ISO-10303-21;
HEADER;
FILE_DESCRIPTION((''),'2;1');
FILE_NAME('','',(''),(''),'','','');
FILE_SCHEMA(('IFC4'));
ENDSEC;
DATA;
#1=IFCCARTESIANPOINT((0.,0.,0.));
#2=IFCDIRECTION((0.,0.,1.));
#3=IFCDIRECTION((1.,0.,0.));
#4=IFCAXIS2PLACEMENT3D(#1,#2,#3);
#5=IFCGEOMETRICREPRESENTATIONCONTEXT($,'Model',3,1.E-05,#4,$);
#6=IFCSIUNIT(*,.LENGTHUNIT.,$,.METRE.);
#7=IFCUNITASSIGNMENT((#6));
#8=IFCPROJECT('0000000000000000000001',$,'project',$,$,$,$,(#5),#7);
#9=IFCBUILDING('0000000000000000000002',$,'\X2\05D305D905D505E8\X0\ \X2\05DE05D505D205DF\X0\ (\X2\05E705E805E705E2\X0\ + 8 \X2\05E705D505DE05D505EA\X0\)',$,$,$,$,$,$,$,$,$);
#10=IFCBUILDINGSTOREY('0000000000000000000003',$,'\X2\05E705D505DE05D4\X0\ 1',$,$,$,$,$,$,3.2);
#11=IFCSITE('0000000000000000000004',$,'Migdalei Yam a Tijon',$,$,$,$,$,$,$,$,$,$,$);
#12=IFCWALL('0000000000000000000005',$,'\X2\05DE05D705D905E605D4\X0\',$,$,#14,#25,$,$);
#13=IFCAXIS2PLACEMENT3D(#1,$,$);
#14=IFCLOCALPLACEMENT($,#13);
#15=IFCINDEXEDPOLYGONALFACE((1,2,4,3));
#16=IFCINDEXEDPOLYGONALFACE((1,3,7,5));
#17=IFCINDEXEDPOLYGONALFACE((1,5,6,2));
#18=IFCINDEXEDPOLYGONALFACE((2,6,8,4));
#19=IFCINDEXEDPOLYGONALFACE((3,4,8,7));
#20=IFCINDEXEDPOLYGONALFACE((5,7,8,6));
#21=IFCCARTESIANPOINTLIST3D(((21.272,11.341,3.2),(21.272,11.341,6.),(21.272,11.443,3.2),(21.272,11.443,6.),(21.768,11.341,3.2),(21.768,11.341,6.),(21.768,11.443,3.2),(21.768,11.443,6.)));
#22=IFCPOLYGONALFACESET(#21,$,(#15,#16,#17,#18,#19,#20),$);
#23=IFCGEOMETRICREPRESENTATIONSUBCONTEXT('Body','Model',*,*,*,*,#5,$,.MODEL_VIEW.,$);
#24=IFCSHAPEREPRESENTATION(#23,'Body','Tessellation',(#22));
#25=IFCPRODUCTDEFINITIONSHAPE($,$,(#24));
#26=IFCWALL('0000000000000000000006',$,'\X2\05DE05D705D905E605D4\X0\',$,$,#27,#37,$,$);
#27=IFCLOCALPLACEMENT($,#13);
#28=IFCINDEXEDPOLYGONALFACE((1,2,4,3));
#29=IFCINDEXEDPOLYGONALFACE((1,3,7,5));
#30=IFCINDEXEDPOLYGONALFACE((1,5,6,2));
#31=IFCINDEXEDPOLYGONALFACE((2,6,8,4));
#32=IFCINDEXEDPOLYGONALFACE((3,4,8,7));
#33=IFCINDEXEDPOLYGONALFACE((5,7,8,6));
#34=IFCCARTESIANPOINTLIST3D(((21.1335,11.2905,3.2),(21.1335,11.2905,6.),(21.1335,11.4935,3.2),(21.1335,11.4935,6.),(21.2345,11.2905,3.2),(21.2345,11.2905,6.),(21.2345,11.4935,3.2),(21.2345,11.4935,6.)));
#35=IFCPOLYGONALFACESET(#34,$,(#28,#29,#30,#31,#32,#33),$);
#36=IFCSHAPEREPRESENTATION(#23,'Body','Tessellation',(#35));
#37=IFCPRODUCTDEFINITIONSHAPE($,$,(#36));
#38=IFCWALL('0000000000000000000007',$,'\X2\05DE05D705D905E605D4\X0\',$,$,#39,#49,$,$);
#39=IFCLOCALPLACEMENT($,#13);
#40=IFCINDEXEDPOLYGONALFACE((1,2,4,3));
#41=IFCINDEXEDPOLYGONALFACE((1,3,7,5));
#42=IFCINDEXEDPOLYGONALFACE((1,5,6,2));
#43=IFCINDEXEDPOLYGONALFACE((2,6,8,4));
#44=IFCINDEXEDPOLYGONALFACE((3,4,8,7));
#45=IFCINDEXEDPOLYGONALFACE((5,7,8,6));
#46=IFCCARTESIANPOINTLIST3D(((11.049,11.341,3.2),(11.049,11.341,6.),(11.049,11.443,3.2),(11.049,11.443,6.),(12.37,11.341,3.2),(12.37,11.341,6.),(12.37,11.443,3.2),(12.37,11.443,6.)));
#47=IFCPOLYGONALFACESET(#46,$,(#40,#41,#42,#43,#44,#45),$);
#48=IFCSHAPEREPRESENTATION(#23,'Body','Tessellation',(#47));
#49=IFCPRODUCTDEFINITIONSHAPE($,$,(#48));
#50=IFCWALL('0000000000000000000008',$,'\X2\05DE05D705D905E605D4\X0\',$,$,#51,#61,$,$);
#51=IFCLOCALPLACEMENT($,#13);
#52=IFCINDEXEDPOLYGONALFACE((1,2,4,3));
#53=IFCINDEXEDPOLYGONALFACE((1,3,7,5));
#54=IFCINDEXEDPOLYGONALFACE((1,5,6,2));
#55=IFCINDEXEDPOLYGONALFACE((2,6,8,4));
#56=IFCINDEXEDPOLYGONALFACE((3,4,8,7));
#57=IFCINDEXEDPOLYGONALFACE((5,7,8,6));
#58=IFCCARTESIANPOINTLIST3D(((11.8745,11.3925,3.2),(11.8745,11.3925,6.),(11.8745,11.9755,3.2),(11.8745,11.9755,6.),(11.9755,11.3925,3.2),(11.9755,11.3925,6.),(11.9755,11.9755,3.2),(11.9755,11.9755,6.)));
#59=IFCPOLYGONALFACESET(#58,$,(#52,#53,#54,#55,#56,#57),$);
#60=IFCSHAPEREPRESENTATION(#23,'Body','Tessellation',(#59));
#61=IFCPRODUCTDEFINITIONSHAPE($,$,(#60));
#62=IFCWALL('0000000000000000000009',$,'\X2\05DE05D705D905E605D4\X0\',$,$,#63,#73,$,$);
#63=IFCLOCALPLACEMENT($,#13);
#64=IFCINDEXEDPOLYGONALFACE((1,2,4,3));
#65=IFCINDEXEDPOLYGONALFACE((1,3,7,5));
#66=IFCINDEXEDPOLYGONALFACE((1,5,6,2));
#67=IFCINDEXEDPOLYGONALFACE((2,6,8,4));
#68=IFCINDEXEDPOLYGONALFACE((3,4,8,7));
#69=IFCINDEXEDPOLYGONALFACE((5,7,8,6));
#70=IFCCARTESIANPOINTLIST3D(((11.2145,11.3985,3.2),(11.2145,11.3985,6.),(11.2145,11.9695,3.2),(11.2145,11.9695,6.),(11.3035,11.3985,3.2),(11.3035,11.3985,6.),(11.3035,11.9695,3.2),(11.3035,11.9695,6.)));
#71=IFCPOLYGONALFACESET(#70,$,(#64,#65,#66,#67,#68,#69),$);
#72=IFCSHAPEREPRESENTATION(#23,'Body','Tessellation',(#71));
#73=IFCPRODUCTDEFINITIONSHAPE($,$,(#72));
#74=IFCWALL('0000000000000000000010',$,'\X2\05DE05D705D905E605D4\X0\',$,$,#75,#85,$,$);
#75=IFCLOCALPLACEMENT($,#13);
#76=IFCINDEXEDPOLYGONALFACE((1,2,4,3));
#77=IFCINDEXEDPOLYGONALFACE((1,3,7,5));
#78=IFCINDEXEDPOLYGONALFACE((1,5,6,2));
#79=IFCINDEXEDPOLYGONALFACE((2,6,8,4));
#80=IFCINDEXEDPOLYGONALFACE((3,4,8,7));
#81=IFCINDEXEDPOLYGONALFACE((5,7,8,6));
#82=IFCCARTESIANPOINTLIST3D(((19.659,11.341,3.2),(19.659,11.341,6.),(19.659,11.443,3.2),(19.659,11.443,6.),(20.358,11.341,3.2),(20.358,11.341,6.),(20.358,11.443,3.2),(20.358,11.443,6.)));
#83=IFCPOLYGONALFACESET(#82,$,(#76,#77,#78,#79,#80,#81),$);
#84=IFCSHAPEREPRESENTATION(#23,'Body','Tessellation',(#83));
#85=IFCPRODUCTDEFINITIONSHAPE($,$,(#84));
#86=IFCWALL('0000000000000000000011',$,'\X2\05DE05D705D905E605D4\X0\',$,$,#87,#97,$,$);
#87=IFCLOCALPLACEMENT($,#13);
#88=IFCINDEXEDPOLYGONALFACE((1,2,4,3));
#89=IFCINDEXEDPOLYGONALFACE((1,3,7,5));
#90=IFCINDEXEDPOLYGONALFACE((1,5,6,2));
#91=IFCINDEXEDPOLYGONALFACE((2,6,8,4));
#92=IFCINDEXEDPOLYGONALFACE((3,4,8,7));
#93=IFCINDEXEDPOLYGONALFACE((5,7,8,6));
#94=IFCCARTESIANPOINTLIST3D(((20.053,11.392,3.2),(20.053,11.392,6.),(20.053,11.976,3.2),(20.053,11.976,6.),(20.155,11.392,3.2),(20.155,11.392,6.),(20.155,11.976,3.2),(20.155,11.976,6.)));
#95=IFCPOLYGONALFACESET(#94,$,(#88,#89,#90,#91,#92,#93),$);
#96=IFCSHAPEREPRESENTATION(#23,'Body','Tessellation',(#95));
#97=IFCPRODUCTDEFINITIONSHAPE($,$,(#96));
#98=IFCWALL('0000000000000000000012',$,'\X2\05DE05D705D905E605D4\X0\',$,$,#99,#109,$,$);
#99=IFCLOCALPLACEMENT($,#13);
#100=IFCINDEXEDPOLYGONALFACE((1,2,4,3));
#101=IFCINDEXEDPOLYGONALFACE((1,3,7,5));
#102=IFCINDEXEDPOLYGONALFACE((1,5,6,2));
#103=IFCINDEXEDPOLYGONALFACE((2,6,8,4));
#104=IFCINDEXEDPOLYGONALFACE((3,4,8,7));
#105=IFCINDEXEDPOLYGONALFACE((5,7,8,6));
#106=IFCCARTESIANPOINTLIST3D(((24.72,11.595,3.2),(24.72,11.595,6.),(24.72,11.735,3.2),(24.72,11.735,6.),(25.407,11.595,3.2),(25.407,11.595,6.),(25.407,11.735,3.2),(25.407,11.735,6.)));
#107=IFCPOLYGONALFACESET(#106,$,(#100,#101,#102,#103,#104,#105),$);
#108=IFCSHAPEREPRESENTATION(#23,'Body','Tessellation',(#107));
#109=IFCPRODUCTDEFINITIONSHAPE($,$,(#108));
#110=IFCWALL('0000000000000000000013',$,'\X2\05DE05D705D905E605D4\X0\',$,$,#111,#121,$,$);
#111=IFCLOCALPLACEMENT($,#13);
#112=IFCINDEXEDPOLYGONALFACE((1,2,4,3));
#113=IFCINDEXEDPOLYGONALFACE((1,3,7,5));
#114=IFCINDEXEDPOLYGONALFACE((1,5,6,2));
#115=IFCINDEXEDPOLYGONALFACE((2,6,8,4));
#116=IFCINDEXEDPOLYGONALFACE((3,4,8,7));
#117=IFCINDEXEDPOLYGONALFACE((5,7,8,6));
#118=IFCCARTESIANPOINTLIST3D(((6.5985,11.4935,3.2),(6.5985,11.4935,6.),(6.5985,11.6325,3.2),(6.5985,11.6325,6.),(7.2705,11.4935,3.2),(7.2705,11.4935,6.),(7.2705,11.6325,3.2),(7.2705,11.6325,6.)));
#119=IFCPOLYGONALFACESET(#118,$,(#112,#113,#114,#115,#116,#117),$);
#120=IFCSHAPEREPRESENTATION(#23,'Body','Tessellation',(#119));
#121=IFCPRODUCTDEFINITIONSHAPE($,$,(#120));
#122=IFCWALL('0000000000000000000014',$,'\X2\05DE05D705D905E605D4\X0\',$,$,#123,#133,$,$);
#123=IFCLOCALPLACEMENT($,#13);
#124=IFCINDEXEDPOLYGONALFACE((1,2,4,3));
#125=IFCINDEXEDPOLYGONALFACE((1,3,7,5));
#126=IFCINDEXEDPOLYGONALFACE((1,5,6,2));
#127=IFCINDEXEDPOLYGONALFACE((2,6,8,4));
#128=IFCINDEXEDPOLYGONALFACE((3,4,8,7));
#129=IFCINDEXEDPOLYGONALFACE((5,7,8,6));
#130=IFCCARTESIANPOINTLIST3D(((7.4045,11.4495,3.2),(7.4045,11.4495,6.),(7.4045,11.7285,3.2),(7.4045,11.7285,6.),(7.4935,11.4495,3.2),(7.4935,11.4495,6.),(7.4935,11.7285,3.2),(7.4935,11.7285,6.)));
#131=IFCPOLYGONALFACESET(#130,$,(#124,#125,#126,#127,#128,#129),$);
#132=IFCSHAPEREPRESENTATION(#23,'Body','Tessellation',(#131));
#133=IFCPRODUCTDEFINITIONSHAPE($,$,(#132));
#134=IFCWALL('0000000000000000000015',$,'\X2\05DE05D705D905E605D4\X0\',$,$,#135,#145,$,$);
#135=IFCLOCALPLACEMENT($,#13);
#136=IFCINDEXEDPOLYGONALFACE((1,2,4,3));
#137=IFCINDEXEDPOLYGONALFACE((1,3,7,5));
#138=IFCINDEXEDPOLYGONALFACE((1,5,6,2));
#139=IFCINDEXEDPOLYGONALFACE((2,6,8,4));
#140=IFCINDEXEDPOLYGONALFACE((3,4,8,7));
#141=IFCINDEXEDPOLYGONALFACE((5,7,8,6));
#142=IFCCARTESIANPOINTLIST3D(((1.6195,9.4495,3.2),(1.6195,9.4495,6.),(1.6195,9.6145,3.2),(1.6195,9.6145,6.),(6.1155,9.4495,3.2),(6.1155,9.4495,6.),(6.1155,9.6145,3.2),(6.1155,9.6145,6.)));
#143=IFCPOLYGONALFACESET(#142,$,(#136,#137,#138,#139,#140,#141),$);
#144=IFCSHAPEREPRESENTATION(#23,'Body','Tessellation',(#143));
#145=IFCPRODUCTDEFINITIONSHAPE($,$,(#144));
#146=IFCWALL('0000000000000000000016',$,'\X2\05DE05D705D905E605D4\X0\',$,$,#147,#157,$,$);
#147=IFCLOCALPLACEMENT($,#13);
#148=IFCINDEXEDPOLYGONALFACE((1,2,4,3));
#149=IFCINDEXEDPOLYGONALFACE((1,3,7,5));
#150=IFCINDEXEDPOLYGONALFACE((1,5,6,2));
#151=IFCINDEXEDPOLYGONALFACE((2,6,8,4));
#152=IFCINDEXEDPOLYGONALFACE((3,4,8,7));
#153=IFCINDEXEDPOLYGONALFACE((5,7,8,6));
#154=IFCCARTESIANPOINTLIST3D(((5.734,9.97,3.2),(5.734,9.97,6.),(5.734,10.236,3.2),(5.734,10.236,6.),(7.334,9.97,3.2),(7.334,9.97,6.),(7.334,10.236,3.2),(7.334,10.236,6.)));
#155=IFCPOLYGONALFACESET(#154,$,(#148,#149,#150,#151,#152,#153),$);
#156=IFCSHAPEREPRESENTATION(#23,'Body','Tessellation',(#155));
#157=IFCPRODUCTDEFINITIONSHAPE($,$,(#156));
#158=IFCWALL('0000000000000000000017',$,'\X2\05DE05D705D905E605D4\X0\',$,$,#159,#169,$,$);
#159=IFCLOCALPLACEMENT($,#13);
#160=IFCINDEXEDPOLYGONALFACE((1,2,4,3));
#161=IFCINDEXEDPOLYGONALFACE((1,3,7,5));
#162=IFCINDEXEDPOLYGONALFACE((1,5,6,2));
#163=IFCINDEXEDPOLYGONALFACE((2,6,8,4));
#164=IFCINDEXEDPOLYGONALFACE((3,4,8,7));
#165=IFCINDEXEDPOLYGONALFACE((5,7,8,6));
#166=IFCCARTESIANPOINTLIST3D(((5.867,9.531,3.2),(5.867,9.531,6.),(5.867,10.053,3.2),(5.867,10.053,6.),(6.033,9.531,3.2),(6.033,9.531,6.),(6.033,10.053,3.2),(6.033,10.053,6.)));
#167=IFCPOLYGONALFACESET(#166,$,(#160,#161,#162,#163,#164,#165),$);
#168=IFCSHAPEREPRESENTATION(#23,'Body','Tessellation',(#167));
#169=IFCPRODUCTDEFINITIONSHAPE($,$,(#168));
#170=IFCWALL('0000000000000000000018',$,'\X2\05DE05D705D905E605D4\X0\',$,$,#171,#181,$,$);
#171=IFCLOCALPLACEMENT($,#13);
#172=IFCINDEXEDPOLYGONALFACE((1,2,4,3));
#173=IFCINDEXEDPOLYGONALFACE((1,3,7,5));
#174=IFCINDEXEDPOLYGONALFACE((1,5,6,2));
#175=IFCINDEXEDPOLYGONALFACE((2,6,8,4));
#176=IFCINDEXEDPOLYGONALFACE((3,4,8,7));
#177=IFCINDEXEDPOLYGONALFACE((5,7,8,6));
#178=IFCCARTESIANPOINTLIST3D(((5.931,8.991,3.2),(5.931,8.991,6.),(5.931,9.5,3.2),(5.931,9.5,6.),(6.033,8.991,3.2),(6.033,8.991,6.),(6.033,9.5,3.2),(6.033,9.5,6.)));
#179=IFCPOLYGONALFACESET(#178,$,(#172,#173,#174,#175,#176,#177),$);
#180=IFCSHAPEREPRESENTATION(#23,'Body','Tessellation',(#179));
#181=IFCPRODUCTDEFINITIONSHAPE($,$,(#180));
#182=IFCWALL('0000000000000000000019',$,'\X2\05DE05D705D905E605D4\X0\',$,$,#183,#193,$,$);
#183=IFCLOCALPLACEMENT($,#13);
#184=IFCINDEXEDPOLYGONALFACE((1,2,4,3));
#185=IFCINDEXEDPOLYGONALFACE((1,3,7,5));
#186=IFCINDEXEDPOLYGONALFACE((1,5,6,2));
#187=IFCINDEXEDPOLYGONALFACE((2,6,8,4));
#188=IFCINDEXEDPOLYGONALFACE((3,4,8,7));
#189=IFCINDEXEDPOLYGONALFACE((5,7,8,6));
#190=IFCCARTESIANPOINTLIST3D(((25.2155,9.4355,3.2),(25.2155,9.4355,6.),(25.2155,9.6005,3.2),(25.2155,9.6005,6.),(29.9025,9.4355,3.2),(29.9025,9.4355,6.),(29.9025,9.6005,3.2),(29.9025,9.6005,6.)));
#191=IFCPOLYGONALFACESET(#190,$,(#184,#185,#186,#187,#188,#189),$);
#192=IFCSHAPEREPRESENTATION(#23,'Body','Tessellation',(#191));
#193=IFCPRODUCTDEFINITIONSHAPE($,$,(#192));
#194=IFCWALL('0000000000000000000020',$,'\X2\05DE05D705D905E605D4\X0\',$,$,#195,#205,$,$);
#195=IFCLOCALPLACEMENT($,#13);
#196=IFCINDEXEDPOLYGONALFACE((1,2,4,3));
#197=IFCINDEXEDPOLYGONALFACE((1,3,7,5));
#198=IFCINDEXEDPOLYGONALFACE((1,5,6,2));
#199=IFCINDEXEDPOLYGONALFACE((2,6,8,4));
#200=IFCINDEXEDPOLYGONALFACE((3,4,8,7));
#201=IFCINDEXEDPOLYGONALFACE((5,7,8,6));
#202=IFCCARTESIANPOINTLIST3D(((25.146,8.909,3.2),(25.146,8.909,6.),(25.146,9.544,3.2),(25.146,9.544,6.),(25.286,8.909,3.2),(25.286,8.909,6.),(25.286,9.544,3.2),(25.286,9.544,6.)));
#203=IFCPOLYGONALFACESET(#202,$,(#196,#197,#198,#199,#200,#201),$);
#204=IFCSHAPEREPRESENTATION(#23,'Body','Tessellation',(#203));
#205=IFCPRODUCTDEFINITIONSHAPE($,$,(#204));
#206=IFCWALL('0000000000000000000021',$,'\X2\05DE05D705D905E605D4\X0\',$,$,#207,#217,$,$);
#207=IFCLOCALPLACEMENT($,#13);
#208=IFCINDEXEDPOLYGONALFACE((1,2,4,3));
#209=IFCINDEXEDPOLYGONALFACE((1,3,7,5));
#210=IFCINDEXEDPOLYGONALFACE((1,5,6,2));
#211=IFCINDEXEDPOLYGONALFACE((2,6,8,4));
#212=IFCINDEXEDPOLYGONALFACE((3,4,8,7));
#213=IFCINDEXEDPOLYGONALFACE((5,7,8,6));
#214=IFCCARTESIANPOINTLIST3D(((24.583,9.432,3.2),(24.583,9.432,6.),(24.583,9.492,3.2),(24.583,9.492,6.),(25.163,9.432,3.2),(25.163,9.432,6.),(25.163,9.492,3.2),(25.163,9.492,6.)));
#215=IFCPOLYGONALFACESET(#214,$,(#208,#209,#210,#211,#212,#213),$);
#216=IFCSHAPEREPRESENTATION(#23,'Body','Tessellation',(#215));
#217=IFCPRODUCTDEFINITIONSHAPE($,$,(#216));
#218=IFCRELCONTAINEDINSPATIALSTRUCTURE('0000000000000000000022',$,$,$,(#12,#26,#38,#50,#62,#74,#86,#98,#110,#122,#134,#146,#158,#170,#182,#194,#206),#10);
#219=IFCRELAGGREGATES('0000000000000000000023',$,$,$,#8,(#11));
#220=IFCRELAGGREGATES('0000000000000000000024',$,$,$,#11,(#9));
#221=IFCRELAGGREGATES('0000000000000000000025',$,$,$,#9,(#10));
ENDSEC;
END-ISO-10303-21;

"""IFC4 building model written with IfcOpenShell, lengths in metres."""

from ifc_helpers import new_model, si_unit, frame, origin_with_axes, context, subcontext, project, spatial, line, indexed_curve, outline, extrude, element, save


model = new_model("IFC4")

# Units and contexts
model_context = context("Model", 3, precision=1e-05, world=origin_with_axes())
body_context = subcontext(model_context, "Body", "Model", "MODEL_VIEW")
ifc_project = project(units=[si_unit("LENGTHUNIT", "METRE")], contexts=[model_context])

# Site, building, storey
site = spatial("IfcSite", under=ifc_project, Name="Migdalei Yam a Tijon")
building = spatial("IfcBuilding", under=site, Name="דיור מוגן (קרקע + 8 קומות)")
storey = spatial("IfcBuildingStorey", under=building, Name="קומה 1", Elevation=3.2)

# Walls
element("IfcWall", 1, inside=storey, Name="מחיצה", context=body_context, shape_type="SweptSolid", body=[
    extrude(outline(indexed_curve([(0.0, 0.0), (0.496, 0.0), (0.496, 0.102), (0.0, 0.102)], segments=[line(1, 2, 3, 4, 1)])), frame((21.272, 11.341, 3.2), z_axis=(0.0, 0.0, 1.0), x_axis=(1.0, 0.0, 0.0)), (0.0, 0.0, 1.0), 2.8),
])
element("IfcWall", 2, inside=storey, Name="מחיצה", context=body_context, shape_type="SweptSolid", body=[
    extrude(outline(indexed_curve([(0.0, 0.0), (0.101, 0.0), (0.101, 0.203), (0.0, 0.203)], segments=[line(1, 2, 3, 4, 1)])), frame((21.1335, 11.2905, 3.2), z_axis=(0.0, 0.0, 1.0), x_axis=(1.0, 0.0, 0.0)), (0.0, 0.0, 1.0), 2.8),
])
element("IfcWall", 3, inside=storey, Name="מחיצה", context=body_context, shape_type="SweptSolid", body=[
    extrude(outline(indexed_curve([(0.0, 0.0), (1.321, 0.0), (1.321, 0.102), (0.0, 0.102)], segments=[line(1, 2, 3, 4, 1)])), frame((11.049, 11.341, 3.2), z_axis=(0.0, 0.0, 1.0), x_axis=(1.0, 0.0, 0.0)), (0.0, 0.0, 1.0), 2.8),
])
element("IfcWall", 4, inside=storey, Name="מחיצה", context=body_context, shape_type="SweptSolid", body=[
    extrude(outline(indexed_curve([(0.0, 0.0), (0.101, 0.0), (0.101, 0.583), (0.0, 0.583)], segments=[line(1, 2, 3, 4, 1)])), frame((11.8745, 11.3925, 3.2), z_axis=(0.0, 0.0, 1.0), x_axis=(1.0, 0.0, 0.0)), (0.0, 0.0, 1.0), 2.8),
])
element("IfcWall", 5, inside=storey, Name="מחיצה", context=body_context, shape_type="SweptSolid", body=[
    extrude(outline(indexed_curve([(0.0, 0.0), (0.089, 0.0), (0.089, 0.571), (0.0, 0.571)], segments=[line(1, 2, 3, 4, 1)])), frame((11.2145, 11.3985, 3.2), z_axis=(0.0, 0.0, 1.0), x_axis=(1.0, 0.0, 0.0)), (0.0, 0.0, 1.0), 2.8),
])
element("IfcWall", 6, inside=storey, Name="מחיצה", context=body_context, shape_type="SweptSolid", body=[
    extrude(outline(indexed_curve([(0.0, 0.0), (0.699, 0.0), (0.699, 0.102), (0.0, 0.102)], segments=[line(1, 2, 3, 4, 1)])), frame((19.659, 11.341, 3.2), z_axis=(0.0, 0.0, 1.0), x_axis=(1.0, 0.0, 0.0)), (0.0, 0.0, 1.0), 2.8),
])
element("IfcWall", 7, inside=storey, Name="מחיצה", context=body_context, shape_type="SweptSolid", body=[
    extrude(outline(indexed_curve([(0.0, 0.0), (0.102, 0.0), (0.102, 0.584), (0.0, 0.584)], segments=[line(1, 2, 3, 4, 1)])), frame((20.053, 11.392, 3.2), z_axis=(0.0, 0.0, 1.0), x_axis=(1.0, 0.0, 0.0)), (0.0, 0.0, 1.0), 2.8),
])
element("IfcWall", 8, inside=storey, Name="מחיצה", context=body_context, shape_type="SweptSolid", body=[
    extrude(outline(indexed_curve([(0.0, 0.0), (0.687, 0.0), (0.687, 0.14), (0.0, 0.14)], segments=[line(1, 2, 3, 4, 1)])), frame((24.72, 11.595, 3.2), z_axis=(0.0, 0.0, 1.0), x_axis=(1.0, 0.0, 0.0)), (0.0, 0.0, 1.0), 2.8),
])
element("IfcWall", 9, inside=storey, Name="מחיצה", context=body_context, shape_type="SweptSolid", body=[
    extrude(outline(indexed_curve([(0.0, 0.0), (0.672, 0.0), (0.672, 0.139), (0.0, 0.139)], segments=[line(1, 2, 3, 4, 1)])), frame((6.5985, 11.4935, 3.2), z_axis=(0.0, 0.0, 1.0), x_axis=(1.0, 0.0, 0.0)), (0.0, 0.0, 1.0), 2.8),
])
element("IfcWall", 10, inside=storey, Name="מחיצה", context=body_context, shape_type="SweptSolid", body=[
    extrude(outline(indexed_curve([(0.0, 0.0), (0.089, 0.0), (0.089, 0.279), (0.0, 0.279)], segments=[line(1, 2, 3, 4, 1)])), frame((7.4045, 11.4495, 3.2), z_axis=(0.0, 0.0, 1.0), x_axis=(1.0, 0.0, 0.0)), (0.0, 0.0, 1.0), 2.8),
])
element("IfcWall", 11, inside=storey, Name="מחיצה", context=body_context, shape_type="SweptSolid", body=[
    extrude(outline(indexed_curve([(0.0, 0.0), (4.496, 0.0), (4.496, 0.165), (0.0, 0.165)], segments=[line(1, 2, 3, 4, 1)])), frame((1.6195, 9.4495, 3.2), z_axis=(0.0, 0.0, 1.0), x_axis=(1.0, 0.0, 0.0)), (0.0, 0.0, 1.0), 2.8),
])
element("IfcWall", 12, inside=storey, Name="מחיצה", context=body_context, shape_type="SweptSolid", body=[
    extrude(outline(indexed_curve([(0.0, 0.0), (1.6, 0.0), (1.6, 0.266), (0.0, 0.266)], segments=[line(1, 2, 3, 4, 1)])), frame((5.734, 9.97, 3.2), z_axis=(0.0, 0.0, 1.0), x_axis=(1.0, 0.0, 0.0)), (0.0, 0.0, 1.0), 2.8),
])
element("IfcWall", 13, inside=storey, Name="מחיצה", context=body_context, shape_type="SweptSolid", body=[
    extrude(outline(indexed_curve([(0.0, 0.0), (0.166, 0.0), (0.166, 0.522), (0.0, 0.522)], segments=[line(1, 2, 3, 4, 1)])), frame((5.867, 9.531, 3.2), z_axis=(0.0, 0.0, 1.0), x_axis=(1.0, 0.0, 0.0)), (0.0, 0.0, 1.0), 2.8),
])
element("IfcWall", 14, inside=storey, Name="מחיצה", context=body_context, shape_type="SweptSolid", body=[
    extrude(outline(indexed_curve([(0.0, 0.0), (0.102, 0.0), (0.102, 0.509), (0.0, 0.509)], segments=[line(1, 2, 3, 4, 1)])), frame((5.931, 8.991, 3.2), z_axis=(0.0, 0.0, 1.0), x_axis=(1.0, 0.0, 0.0)), (0.0, 0.0, 1.0), 2.8),
])
element("IfcWall", 15, inside=storey, Name="מחיצה", context=body_context, shape_type="SweptSolid", body=[
    extrude(outline(indexed_curve([(0.0, 0.0), (4.687, 0.0), (4.687, 0.165), (0.0, 0.165)], segments=[line(1, 2, 3, 4, 1)])), frame((25.2155, 9.4355, 3.2), z_axis=(0.0, 0.0, 1.0), x_axis=(1.0, 0.0, 0.0)), (0.0, 0.0, 1.0), 2.8),
])
element("IfcWall", 16, inside=storey, Name="מחיצה", context=body_context, shape_type="SweptSolid", body=[
    extrude(outline(indexed_curve([(0.0, 0.0), (0.14, 0.0), (0.14, 0.635), (0.0, 0.635)], segments=[line(1, 2, 3, 4, 1)])), frame((25.146, 8.909, 3.2), z_axis=(0.0, 0.0, 1.0), x_axis=(1.0, 0.0, 0.0)), (0.0, 0.0, 1.0), 2.8),
])
element("IfcWall", 17, inside=storey, Name="מחיצה", context=body_context, shape_type="SweptSolid", body=[
    extrude(outline(indexed_curve([(0.0, 0.0), (0.58, 0.0), (0.58, 0.06), (0.0, 0.06)], segments=[line(1, 2, 3, 4, 1)])), frame((24.583, 9.432, 3.2), z_axis=(0.0, 0.0, 1.0), x_axis=(1.0, 0.0, 0.0)), (0.0, 0.0, 1.0), 2.8),
])

save(model, "model.ifc")
